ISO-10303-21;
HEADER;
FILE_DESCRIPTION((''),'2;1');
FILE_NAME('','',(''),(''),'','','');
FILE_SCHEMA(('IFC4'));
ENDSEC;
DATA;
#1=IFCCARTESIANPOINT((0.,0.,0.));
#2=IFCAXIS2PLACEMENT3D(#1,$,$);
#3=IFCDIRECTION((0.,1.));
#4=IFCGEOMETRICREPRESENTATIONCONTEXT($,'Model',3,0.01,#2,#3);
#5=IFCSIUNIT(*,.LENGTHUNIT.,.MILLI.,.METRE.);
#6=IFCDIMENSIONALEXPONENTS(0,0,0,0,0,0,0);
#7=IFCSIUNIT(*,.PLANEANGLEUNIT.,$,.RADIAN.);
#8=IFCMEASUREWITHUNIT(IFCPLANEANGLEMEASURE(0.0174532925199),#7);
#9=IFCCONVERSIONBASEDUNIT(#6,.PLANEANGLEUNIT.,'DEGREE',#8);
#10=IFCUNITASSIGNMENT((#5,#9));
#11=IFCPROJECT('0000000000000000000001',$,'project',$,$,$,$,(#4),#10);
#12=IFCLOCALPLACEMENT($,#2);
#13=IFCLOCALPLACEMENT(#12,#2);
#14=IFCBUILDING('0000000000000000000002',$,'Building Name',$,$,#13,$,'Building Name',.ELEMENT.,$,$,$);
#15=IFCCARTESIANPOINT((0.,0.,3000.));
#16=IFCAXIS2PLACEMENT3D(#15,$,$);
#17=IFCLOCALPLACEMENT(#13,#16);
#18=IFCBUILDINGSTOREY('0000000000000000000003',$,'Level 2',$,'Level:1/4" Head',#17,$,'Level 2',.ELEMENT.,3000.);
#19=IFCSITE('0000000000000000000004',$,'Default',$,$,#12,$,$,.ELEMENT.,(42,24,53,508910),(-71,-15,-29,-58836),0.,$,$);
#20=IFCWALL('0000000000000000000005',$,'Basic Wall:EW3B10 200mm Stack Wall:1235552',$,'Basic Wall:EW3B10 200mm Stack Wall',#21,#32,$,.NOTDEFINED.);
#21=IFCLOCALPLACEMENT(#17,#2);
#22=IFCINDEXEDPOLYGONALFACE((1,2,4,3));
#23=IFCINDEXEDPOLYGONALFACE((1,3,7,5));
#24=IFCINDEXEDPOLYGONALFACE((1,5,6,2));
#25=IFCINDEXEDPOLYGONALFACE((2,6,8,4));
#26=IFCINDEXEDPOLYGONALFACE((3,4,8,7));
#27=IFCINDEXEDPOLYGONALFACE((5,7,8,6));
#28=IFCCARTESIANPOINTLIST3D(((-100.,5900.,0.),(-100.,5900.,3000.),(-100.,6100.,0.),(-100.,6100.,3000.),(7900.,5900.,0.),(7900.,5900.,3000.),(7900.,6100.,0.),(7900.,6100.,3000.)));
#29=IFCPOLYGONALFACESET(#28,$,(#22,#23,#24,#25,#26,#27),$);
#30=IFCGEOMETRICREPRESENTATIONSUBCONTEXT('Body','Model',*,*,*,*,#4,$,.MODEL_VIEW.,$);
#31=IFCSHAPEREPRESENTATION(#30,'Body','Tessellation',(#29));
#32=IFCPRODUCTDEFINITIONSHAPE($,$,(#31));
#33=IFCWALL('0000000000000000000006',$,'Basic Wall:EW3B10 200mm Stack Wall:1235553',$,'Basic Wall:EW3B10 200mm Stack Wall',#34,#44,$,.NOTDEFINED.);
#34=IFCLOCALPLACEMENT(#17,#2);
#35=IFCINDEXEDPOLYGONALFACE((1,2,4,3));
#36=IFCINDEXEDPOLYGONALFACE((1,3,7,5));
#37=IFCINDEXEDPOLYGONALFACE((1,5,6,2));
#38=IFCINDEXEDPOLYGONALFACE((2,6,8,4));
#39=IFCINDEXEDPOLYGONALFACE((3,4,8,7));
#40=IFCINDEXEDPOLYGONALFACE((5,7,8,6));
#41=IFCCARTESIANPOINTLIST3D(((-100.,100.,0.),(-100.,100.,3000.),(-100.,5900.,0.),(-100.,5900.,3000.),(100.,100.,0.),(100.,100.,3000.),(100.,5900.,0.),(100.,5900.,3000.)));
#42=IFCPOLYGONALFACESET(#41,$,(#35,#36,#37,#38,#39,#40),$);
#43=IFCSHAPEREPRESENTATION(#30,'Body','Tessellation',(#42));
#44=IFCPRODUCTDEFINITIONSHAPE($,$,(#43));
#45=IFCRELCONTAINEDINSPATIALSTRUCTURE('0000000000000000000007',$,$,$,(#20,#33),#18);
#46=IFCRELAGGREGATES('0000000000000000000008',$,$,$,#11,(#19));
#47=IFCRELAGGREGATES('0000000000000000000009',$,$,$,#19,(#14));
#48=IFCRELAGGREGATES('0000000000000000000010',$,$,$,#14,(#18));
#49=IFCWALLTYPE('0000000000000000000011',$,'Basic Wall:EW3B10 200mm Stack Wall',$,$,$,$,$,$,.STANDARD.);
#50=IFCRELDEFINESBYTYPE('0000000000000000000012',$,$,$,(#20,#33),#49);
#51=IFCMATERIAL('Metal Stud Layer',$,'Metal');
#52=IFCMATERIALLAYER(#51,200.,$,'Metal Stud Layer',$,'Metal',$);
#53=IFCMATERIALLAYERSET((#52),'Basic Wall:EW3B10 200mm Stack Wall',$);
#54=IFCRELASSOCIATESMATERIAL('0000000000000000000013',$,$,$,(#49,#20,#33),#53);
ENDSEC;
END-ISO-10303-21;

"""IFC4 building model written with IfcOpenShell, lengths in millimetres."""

from ifc_helpers import new_model, entity, si_unit, converted_unit, direction, frame, frame_2d, origin, place, context, subcontext, project, spatial, rectangle, extrude, material, layer, layer_set, layer_usage, type_object, element, save


model = new_model("IFC4")

# Units and contexts
model_context = context("Model", 3, precision=0.01, world=origin(), true_north=direction((0.0, 1.0)))
body_context = subcontext(model_context, "Body", "Model", "MODEL_VIEW")
ifc_project = project(units=[si_unit("LENGTHUNIT", "METRE", prefix="MILLI"), converted_unit("PLANEANGLEUNIT", "DEGREE", entity("IfcPlaneAngleMeasure", 0.0174532925199), si_unit("PLANEANGLEUNIT", "RADIAN"), dimensions=[0, 0, 0, 0, 0, 0, 0])], contexts=[model_context])

# Site, building, storey
site_placement = place(None, origin())
site = spatial("IfcSite", under=ifc_project, at=site_placement, Name="Default", CompositionType="ELEMENT", RefLatitude=(42, 24, 53, 508910), RefLongitude=(-71, -15, -29, -58836), RefElevation=0.0)
building_placement = place(site_placement, origin())
building = spatial("IfcBuilding", under=site, at=building_placement, Name="Building Name", LongName="Building Name", CompositionType="ELEMENT")
storey_placement = place(building_placement, frame((0.0, 0.0, 3000.0)))
storey = spatial("IfcBuildingStorey", under=building, at=storey_placement, Name="Level 2", ObjectType="Level:1/4\" Head", LongName="Level 2", CompositionType="ELEMENT", Elevation=3000.0)

# Shared definitions
ifc_material_1 = material(Name="Metal Stud Layer", Category="Metal")
ifc_layer_1 = layer(ifc_material_1, 200.0, Name="Metal Stud Layer", Category="Metal")
ifc_layer_set_1 = layer_set([ifc_layer_1], Name="Basic Wall:EW3B10 200mm Stack Wall")
wall_type = type_object("IfcWallType", Name="Basic Wall:EW3B10 200mm Stack Wall", PredefinedType="STANDARD", material=ifc_layer_set_1)

# Walls
ifc_layer_usage_1 = layer_usage(ifc_layer_set_1, "AXIS2", "NEGATIVE", 100.0)
wall_1_placement = place(storey_placement, frame((7900.0, 6000.0, 0.0), z_axis=(0.0, 0.0, 1.0), x_axis=(-1.0, 0.0, 0.0)))
element("IfcWall", 1, at=wall_1_placement, inside=storey, type_object=wall_type, material=ifc_layer_usage_1, Name="Basic Wall:EW3B10 200mm Stack Wall:1235552", ObjectType="Basic Wall:EW3B10 200mm Stack Wall", PredefinedType="NOTDEFINED", context=body_context, shape_type="SweptSolid", body=[
    extrude(rectangle(XDim=8000.0, YDim=200.0, at=frame_2d((4000.0, 0.0), x_axis=(-1.0, 0.0))), origin(), (0.0, 0.0, 1.0), 3000.0),
])
ifc_layer_usage_2 = layer_usage(ifc_layer_set_1, "AXIS2", "NEGATIVE", 100.0)
wall_2_placement = place(storey_placement, frame((0.0, 5900.0, 0.0), z_axis=(0.0, 0.0, 1.0), x_axis=(0.0, -1.0, 0.0)))
element("IfcWall", 2, at=wall_2_placement, inside=storey, type_object=wall_type, material=ifc_layer_usage_2, Name="Basic Wall:EW3B10 200mm Stack Wall:1235553", ObjectType="Basic Wall:EW3B10 200mm Stack Wall", PredefinedType="NOTDEFINED", context=body_context, shape_type="SweptSolid", body=[
    extrude(rectangle(XDim=5800.0, YDim=200.0, at=frame_2d((2900.0, 0.0), x_axis=(-1.0, 0.0))), origin(), (0.0, 0.0, 1.0), 3000.0),
])

save(model, "model.ifc")
